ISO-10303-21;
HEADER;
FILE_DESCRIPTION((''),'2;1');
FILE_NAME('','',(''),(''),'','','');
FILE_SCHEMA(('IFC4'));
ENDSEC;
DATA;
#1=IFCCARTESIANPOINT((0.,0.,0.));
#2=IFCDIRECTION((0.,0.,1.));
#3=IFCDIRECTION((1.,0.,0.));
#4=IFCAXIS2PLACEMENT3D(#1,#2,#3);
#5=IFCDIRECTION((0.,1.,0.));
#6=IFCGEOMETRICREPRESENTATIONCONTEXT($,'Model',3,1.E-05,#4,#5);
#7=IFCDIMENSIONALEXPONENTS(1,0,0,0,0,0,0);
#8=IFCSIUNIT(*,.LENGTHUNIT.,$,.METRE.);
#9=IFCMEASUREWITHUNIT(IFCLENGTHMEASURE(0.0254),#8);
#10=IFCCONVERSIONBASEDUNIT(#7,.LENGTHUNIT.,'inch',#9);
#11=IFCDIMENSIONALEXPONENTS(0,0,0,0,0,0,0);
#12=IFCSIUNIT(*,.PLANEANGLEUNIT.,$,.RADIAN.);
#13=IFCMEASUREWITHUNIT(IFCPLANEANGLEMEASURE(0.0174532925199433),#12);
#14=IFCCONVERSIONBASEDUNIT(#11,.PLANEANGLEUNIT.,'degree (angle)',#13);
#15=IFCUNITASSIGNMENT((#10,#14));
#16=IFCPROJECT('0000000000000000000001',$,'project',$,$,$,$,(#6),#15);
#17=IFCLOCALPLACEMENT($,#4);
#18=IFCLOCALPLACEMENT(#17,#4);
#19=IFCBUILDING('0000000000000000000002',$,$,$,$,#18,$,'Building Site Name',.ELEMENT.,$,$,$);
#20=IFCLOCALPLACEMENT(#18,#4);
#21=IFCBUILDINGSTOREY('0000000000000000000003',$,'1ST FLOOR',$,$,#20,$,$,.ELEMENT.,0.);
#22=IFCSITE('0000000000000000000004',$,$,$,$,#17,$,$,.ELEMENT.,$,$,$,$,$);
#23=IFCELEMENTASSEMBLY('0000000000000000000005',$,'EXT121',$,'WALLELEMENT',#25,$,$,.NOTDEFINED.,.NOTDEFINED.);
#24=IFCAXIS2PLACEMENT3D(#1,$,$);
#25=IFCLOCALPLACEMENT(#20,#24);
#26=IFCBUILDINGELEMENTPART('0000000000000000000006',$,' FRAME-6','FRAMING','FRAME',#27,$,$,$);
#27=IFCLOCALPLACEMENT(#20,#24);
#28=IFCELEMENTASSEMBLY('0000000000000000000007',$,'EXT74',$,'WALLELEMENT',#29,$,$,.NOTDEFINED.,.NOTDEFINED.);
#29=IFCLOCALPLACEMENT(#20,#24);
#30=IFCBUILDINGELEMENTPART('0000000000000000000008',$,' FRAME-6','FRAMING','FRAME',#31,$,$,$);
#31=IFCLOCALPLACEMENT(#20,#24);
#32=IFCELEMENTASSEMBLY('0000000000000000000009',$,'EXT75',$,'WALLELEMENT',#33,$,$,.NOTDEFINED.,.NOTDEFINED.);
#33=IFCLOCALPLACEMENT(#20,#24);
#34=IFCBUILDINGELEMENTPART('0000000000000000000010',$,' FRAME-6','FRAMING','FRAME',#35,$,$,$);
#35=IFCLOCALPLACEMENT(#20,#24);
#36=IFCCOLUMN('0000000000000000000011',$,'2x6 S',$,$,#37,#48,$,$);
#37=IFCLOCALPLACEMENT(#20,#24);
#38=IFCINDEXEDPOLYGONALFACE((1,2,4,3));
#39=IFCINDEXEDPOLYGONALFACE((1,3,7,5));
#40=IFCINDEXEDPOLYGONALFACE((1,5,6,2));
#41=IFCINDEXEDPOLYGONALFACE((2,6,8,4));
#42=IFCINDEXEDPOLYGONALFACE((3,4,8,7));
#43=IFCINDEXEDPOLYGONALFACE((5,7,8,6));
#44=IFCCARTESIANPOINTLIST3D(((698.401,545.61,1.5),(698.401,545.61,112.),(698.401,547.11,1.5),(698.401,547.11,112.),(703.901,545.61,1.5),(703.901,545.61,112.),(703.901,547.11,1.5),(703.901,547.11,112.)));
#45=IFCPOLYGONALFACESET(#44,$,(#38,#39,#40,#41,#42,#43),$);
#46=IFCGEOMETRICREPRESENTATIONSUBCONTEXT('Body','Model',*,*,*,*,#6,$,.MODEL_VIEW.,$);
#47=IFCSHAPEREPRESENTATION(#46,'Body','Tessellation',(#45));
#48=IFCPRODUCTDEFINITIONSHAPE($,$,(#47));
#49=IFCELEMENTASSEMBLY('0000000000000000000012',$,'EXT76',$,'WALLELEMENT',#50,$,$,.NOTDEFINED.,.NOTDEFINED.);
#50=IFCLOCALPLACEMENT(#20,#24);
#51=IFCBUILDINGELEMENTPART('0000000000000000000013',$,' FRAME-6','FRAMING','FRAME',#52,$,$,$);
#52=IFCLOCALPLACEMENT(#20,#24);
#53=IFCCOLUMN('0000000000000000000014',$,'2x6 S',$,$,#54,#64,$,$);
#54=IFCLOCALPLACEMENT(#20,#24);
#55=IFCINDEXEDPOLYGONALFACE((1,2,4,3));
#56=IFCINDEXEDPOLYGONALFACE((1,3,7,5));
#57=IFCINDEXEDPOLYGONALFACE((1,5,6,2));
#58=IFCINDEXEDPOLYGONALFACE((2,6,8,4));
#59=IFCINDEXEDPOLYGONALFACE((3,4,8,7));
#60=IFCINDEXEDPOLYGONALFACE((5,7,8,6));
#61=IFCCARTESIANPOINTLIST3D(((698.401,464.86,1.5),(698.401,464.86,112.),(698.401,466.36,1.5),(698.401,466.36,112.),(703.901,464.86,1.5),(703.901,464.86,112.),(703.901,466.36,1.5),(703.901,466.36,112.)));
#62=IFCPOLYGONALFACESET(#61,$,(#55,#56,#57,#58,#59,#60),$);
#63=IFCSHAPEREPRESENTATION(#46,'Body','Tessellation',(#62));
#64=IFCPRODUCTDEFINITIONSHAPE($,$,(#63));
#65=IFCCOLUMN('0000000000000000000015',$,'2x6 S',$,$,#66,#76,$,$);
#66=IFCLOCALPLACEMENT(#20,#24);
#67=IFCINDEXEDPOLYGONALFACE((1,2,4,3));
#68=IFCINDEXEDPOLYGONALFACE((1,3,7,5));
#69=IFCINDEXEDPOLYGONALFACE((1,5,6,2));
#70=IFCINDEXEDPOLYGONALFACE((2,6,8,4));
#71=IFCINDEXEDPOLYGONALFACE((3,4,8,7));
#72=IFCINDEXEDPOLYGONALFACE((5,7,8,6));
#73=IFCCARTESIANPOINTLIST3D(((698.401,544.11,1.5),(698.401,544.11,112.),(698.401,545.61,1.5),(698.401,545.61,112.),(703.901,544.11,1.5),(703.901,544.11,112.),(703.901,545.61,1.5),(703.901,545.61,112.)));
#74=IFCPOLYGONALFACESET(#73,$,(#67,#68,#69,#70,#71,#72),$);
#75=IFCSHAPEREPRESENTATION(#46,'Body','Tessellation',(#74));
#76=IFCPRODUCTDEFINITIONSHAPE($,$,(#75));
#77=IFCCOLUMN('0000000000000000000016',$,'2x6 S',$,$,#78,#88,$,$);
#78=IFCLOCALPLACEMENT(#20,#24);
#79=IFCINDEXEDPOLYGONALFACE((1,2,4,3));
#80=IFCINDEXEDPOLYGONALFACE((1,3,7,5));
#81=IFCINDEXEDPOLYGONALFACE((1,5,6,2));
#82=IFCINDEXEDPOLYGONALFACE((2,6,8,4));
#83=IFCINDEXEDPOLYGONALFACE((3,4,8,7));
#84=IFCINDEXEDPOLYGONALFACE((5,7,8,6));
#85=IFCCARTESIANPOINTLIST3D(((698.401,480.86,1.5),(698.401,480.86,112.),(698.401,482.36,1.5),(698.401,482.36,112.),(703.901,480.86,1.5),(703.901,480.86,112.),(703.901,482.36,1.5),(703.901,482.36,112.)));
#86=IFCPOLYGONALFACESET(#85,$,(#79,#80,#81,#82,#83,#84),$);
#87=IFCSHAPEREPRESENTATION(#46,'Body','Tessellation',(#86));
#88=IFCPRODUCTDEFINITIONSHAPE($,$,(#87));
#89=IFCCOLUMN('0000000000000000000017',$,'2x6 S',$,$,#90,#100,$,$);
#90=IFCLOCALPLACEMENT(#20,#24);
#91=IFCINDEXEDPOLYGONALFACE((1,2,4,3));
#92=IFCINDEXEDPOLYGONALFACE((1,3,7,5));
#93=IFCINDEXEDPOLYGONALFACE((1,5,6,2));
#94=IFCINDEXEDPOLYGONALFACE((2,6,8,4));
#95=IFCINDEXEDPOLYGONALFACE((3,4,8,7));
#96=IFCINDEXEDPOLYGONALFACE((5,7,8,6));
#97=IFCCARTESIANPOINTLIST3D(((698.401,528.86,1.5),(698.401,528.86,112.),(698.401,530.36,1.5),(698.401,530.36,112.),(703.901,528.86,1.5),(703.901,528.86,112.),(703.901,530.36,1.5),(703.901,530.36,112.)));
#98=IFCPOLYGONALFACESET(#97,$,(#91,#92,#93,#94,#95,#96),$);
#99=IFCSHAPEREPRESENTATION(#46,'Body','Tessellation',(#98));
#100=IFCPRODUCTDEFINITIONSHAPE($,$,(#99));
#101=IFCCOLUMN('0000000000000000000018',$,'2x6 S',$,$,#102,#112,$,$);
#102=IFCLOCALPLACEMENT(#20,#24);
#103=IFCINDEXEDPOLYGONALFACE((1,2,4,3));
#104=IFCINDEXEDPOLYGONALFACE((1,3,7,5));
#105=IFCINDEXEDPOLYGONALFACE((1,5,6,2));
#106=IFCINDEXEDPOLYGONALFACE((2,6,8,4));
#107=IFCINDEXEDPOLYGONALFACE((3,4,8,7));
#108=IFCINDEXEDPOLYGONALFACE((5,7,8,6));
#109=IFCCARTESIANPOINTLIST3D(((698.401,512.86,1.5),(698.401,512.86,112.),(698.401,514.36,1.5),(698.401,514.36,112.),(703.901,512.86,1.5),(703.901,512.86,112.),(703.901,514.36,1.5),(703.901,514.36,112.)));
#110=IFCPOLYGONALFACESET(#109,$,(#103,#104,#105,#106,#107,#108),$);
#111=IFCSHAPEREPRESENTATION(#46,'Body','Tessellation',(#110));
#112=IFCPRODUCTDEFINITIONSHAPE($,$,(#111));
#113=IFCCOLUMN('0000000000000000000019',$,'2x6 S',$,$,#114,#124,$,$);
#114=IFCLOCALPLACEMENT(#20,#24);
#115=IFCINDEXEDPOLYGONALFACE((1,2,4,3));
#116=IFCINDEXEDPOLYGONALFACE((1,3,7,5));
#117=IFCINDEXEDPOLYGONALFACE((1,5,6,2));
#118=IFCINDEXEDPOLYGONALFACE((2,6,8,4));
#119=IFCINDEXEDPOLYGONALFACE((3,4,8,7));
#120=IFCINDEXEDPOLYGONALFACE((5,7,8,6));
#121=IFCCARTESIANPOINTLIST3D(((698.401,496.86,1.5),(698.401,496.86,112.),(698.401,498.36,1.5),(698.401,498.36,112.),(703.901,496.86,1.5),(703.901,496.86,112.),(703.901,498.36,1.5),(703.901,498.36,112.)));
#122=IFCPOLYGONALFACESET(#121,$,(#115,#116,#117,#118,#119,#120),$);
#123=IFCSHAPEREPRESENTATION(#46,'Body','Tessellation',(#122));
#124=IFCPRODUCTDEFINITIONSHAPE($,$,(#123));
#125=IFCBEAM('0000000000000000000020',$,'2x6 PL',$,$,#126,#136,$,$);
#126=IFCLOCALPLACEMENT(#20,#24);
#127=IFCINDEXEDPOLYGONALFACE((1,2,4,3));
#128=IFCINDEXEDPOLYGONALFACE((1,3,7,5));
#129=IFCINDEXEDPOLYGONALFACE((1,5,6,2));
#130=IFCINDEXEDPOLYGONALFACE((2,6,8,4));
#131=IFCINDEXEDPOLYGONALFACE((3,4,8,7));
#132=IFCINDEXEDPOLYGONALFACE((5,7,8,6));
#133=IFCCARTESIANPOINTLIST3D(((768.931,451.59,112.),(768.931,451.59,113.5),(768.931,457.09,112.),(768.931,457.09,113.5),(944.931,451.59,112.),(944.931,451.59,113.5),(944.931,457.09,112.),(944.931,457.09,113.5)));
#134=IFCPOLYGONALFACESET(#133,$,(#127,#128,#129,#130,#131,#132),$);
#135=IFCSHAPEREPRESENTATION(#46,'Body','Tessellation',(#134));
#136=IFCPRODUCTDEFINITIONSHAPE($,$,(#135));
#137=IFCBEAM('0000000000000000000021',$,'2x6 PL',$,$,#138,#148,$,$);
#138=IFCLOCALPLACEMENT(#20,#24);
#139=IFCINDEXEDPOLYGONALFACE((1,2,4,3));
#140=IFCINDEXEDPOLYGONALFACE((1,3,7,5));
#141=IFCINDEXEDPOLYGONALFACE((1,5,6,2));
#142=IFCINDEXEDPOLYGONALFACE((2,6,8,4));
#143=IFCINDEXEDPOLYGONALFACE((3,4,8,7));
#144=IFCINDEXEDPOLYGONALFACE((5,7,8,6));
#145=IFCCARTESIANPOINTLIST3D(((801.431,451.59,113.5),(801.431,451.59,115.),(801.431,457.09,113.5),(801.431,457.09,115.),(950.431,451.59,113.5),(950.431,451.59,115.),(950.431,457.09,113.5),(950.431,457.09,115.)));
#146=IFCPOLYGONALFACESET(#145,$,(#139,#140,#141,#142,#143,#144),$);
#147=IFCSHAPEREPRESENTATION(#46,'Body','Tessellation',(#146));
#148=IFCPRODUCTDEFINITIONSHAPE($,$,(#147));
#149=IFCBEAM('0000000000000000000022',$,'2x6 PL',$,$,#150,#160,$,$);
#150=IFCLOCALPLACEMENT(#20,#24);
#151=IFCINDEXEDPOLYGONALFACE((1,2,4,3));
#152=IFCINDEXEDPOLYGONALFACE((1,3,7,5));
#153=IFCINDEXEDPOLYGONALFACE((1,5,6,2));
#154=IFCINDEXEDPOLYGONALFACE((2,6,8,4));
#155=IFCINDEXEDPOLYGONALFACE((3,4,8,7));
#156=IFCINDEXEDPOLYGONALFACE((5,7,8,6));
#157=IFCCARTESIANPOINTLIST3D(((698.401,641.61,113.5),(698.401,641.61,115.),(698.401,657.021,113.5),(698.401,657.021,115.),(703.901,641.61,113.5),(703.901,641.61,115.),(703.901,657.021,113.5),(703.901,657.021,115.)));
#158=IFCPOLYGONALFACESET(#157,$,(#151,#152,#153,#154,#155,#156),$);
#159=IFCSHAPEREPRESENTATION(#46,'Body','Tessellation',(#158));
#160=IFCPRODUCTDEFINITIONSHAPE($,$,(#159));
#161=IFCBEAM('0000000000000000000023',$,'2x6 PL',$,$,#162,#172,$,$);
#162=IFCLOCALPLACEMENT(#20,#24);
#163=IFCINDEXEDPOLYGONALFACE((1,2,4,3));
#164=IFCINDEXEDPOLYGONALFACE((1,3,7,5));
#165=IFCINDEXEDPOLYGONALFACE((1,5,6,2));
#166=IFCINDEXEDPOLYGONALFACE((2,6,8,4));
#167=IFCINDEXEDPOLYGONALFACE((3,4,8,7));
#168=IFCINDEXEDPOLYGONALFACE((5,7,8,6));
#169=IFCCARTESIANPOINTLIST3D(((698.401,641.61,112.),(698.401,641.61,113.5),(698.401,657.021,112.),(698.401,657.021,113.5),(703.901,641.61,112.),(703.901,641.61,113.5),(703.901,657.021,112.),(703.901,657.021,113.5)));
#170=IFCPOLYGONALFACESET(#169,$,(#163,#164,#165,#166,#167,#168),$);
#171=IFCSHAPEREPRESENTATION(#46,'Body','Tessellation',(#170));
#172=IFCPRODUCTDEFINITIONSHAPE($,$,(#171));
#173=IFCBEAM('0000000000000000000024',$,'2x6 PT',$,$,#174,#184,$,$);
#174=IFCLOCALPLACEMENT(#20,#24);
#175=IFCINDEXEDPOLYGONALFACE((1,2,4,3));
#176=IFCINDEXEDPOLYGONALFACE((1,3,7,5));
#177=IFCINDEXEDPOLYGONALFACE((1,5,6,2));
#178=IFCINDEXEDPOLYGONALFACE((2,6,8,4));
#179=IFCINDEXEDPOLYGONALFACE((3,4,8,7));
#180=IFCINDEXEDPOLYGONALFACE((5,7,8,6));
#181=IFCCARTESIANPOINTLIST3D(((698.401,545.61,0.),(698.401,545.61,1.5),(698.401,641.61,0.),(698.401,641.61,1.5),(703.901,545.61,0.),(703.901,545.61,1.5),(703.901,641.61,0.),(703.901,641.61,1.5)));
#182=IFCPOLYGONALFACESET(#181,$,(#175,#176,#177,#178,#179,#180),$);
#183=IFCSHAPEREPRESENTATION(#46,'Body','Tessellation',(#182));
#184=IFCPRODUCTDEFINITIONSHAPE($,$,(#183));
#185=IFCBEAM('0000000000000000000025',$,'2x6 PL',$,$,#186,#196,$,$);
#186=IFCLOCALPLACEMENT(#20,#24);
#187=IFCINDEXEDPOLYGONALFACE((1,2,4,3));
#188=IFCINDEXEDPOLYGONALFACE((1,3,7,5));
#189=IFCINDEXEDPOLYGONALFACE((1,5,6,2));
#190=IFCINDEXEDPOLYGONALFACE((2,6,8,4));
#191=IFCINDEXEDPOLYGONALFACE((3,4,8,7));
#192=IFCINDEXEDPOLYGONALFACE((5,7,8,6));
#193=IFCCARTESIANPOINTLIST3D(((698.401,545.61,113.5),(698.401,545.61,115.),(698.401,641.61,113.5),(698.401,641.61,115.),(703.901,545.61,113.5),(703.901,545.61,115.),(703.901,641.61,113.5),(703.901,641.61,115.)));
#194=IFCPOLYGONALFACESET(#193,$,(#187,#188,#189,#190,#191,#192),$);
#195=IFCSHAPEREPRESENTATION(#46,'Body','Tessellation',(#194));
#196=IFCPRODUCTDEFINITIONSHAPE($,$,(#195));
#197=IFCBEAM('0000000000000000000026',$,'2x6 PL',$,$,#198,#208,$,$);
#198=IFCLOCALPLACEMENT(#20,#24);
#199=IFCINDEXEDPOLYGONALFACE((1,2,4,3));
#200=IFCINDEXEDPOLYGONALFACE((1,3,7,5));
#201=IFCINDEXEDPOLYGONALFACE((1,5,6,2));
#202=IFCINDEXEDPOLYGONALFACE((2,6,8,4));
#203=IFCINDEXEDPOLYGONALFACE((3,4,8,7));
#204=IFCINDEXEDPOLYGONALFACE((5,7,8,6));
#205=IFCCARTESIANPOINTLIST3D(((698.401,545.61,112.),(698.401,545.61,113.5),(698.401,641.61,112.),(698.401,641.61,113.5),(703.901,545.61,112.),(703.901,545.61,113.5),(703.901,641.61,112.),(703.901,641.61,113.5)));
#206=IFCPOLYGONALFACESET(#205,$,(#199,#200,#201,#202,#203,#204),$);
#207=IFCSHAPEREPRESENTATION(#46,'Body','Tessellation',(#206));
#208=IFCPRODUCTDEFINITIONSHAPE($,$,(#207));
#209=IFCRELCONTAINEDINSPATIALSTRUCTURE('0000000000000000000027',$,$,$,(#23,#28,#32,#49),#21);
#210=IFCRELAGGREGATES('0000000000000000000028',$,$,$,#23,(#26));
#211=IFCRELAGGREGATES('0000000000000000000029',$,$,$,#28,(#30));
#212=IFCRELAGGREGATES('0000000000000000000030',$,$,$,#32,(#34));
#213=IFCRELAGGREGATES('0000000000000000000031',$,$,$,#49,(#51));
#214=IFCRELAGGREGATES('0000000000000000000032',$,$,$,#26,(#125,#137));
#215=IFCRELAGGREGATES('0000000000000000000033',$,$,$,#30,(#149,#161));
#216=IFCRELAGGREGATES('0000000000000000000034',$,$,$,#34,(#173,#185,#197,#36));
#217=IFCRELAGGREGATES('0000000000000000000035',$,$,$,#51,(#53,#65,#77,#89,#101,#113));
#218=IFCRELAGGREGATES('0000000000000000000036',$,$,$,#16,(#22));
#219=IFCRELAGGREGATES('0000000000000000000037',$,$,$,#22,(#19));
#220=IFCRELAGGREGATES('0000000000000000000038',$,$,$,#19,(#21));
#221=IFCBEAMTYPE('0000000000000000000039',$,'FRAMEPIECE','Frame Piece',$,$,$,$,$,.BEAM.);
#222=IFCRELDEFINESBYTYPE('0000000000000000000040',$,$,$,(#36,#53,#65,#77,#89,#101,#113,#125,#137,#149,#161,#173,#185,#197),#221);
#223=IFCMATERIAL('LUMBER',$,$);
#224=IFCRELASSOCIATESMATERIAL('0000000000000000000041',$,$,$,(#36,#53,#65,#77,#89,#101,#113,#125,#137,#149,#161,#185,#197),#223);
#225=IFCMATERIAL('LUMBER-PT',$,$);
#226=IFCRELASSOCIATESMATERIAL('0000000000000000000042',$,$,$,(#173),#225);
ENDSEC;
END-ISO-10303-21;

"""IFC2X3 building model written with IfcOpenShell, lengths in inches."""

from ifc_helpers import new_model, entity, si_unit, converted_unit, direction, frame, frame_2d, origin_with_axes, place, context, subcontext, project, spatial, rectangle, extrude, material, type_object, element, aggregate, save


model = new_model("IFC2X3")

# Units and contexts
model_context = context("Model", 3, precision=1e-05, world=origin_with_axes(), true_north=direction((0.0, 1.0, 0.0)))
body_context = subcontext(model_context, "Body", "Model", "MODEL_VIEW")
ifc_project = project(units=[converted_unit("LENGTHUNIT", "inch", entity("IfcLengthMeasure", 0.0254), si_unit("LENGTHUNIT", "METRE"), dimensions=[1, 0, 0, 0, 0, 0, 0]), converted_unit("PLANEANGLEUNIT", "degree (angle)", entity("IfcPlaneAngleMeasure", 0.0174532925199433), si_unit("PLANEANGLEUNIT", "RADIAN"), dimensions=[0, 0, 0, 0, 0, 0, 0])], contexts=[model_context])

# Site, building, storey
site_placement = place(None, origin_with_axes())
site = spatial("IfcSite", under=ifc_project, at=site_placement, CompositionType="ELEMENT")
building_placement = place(site_placement, origin_with_axes())
building = spatial("IfcBuilding", under=site, at=building_placement, LongName="Building Site Name", CompositionType="ELEMENT")
storey_placement = place(building_placement, origin_with_axes())
storey = spatial("IfcBuildingStorey", under=building, at=storey_placement, Name="1ST FLOOR", CompositionType="ELEMENT", Elevation=0.0)

# Element assembly, building element part
assembly_1_placement = place(storey_placement, origin_with_axes())
assembly_1 = element("IfcElementAssembly", 1, at=assembly_1_placement, inside=storey, Name="EXT121", ObjectType="WALLELEMENT", AssemblyPlace="NOTDEFINED", PredefinedType="NOTDEFINED")
building_element_part_1 = element("IfcBuildingElementPart", 2, Name=" FRAME-6", Description="FRAMING", ObjectType="FRAME")
aggregate(assembly_1, [building_element_part_1])
ifc_material_1 = material(Name="LUMBER")
beam_type = type_object("IfcBeamType", Name="FRAMEPIECE", Description="Frame Piece", PredefinedType="BEAM")

# Element assembly, building element part
assembly_2_placement = place(storey_placement, origin_with_axes())
assembly_2 = element("IfcElementAssembly", 3, at=assembly_2_placement, inside=storey, Name="EXT74", ObjectType="WALLELEMENT", AssemblyPlace="NOTDEFINED", PredefinedType="NOTDEFINED")
building_element_part_2 = element("IfcBuildingElementPart", 4, Name=" FRAME-6", Description="FRAMING", ObjectType="FRAME")
aggregate(assembly_2, [building_element_part_2])

# Element assemblies, building element parts, columns
assembly_3_placement = place(storey_placement, origin_with_axes())
assembly_3 = element("IfcElementAssembly", 5, at=assembly_3_placement, inside=storey, Name="EXT75", ObjectType="WALLELEMENT", AssemblyPlace="NOTDEFINED", PredefinedType="NOTDEFINED")
building_element_part_3 = element("IfcBuildingElementPart", 6, Name=" FRAME-6", Description="FRAMING", ObjectType="FRAME")
aggregate(assembly_3, [building_element_part_3])
column_1_placement = place(assembly_3_placement, frame((701.151, 546.36, 1.5), z_axis=(0.0, 0.0, 1.0), x_axis=(0.0, 1.0, 0.0)))
column_1 = element("IfcColumn", 7, at=column_1_placement, type_object=beam_type, material=ifc_material_1, Name="2x6 S", context=body_context, shape_type="SweptSolid", body=[
    extrude(rectangle(XDim=1.5, YDim=5.5, at=frame_2d((0.0, 0.0), x_axis=(-1.0, 0.0))), frame((0.0, 0.0, 0.0), z_axis=(0.0, 0.0, 1.0), x_axis=(1.0, 0.0, 0.0)), (0.0, 0.0, 1.0), 110.5),
])
assembly_4_placement = place(storey_placement, origin_with_axes())
assembly_4 = element("IfcElementAssembly", 8, at=assembly_4_placement, inside=storey, Name="EXT76", ObjectType="WALLELEMENT", AssemblyPlace="NOTDEFINED", PredefinedType="NOTDEFINED")
building_element_part_4 = element("IfcBuildingElementPart", 9, Name=" FRAME-6", Description="FRAMING", ObjectType="FRAME")
aggregate(assembly_4, [building_element_part_4])
column_2_placement = place(assembly_4_placement, frame((701.151, 465.61, 112.0), z_axis=(0.0, 0.0, -1.0), x_axis=(0.0, -1.0, 0.0)))
column_2 = element("IfcColumn", 10, at=column_2_placement, type_object=beam_type, material=ifc_material_1, Name="2x6 S", context=body_context, shape_type="SweptSolid", body=[
    extrude(rectangle(XDim=1.5, YDim=5.5, at=frame_2d((0.0, 0.0), x_axis=(-1.0, 0.0))), origin_with_axes(), (0.0, 0.0, 1.0), 110.5),
])
column_3_placement = place(assembly_4_placement, frame((701.151, 544.86, 112.0), z_axis=(0.0, 0.0, -1.0), x_axis=(0.0, -1.0, 0.0)))
column_3 = element("IfcColumn", 11, at=column_3_placement, type_object=beam_type, material=ifc_material_1, Name="2x6 S", context=body_context, shape_type="SweptSolid", body=[
    extrude(rectangle(XDim=1.5, YDim=5.5, at=frame_2d((0.0, 0.0), x_axis=(-1.0, 0.0))), origin_with_axes(), (0.0, 0.0, 1.0), 110.5),
])
column_4_placement = place(assembly_4_placement, frame((701.151, 481.61, 112.0), z_axis=(0.0, 0.0, -1.0), x_axis=(0.0, -1.0, 0.0)))
column_4 = element("IfcColumn", 12, at=column_4_placement, type_object=beam_type, material=ifc_material_1, Name="2x6 S", context=body_context, shape_type="SweptSolid", body=[
    extrude(rectangle(XDim=1.5, YDim=5.5, at=frame_2d((0.0, 0.0), x_axis=(-1.0, 0.0))), origin_with_axes(), (0.0, 0.0, 1.0), 110.5),
])
column_5_placement = place(assembly_4_placement, frame((701.151, 529.61, 112.0), z_axis=(0.0, 0.0, -1.0), x_axis=(0.0, -1.0, 0.0)))
column_5 = element("IfcColumn", 13, at=column_5_placement, type_object=beam_type, material=ifc_material_1, Name="2x6 S", context=body_context, shape_type="SweptSolid", body=[
    extrude(rectangle(XDim=1.5, YDim=5.5, at=frame_2d((0.0, 0.0), x_axis=(-1.0, 0.0))), origin_with_axes(), (0.0, 0.0, 1.0), 110.5),
])
column_6_placement = place(assembly_4_placement, frame((701.151, 513.61, 112.0), z_axis=(0.0, 0.0, -1.0), x_axis=(0.0, -1.0, 0.0)))
column_6 = element("IfcColumn", 14, at=column_6_placement, type_object=beam_type, material=ifc_material_1, Name="2x6 S", context=body_context, shape_type="SweptSolid", body=[
    extrude(rectangle(XDim=1.5, YDim=5.5, at=frame_2d((0.0, 0.0), x_axis=(-1.0, 0.0))), origin_with_axes(), (0.0, 0.0, 1.0), 110.5),
])
column_7_placement = place(assembly_4_placement, frame((701.151, 497.61, 112.0), z_axis=(0.0, 0.0, -1.0), x_axis=(0.0, -1.0, 0.0)))
column_7 = element("IfcColumn", 15, at=column_7_placement, type_object=beam_type, material=ifc_material_1, Name="2x6 S", context=body_context, shape_type="SweptSolid", body=[
    extrude(rectangle(XDim=1.5, YDim=5.5, at=frame_2d((0.0, 0.0), x_axis=(-1.0, 0.0))), origin_with_axes(), (0.0, 0.0, 1.0), 110.5),
])

# Beams
beam_1_placement = place(assembly_1_placement, frame((768.931, 454.34, 112.75), z_axis=(1.0, 0.0, 0.0), x_axis=(0.0, 0.0, -1.0)))
beam_1 = element("IfcBeam", 16, at=beam_1_placement, type_object=beam_type, material=ifc_material_1, Name="2x6 PL", context=body_context, shape_type="SweptSolid", body=[
    extrude(rectangle(XDim=1.5, YDim=5.5, at=frame_2d((0.0, 0.0), x_axis=(-1.0, 0.0))), origin_with_axes(), (0.0, 0.0, 1.0), 176.0),
])
beam_2_placement = place(assembly_1_placement, frame((801.431, 454.34, 114.25), z_axis=(1.0, 0.0, 0.0), x_axis=(0.0, 0.0, -1.0)))
beam_2 = element("IfcBeam", 17, at=beam_2_placement, type_object=beam_type, material=ifc_material_1, Name="2x6 PL", context=body_context, shape_type="SweptSolid", body=[
    extrude(rectangle(XDim=1.5, YDim=5.5, at=frame_2d((0.0, 0.0), x_axis=(-1.0, 0.0))), origin_with_axes(), (0.0, 0.0, 1.0), 149.0),
])
aggregate(building_element_part_1, [beam_1, beam_2])
beam_3_placement = place(assembly_2_placement, frame((701.151, 641.61, 114.25), z_axis=(0.0, 1.0, 0.0), x_axis=(0.0, 0.0, -1.0)))
beam_3 = element("IfcBeam", 18, at=beam_3_placement, type_object=beam_type, material=ifc_material_1, Name="2x6 PL", context=body_context, shape_type="SweptSolid", body=[
    extrude(rectangle(XDim=1.5, YDim=5.5, at=frame_2d((0.0, 0.0), x_axis=(-1.0, 0.0))), origin_with_axes(), (0.0, 0.0, 1.0), 15.412),
])
beam_4_placement = place(assembly_2_placement, frame((701.151, 641.61, 112.75), z_axis=(0.0, 1.0, 0.0), x_axis=(0.0, 0.0, -1.0)))
beam_4 = element("IfcBeam", 19, at=beam_4_placement, type_object=beam_type, material=ifc_material_1, Name="2x6 PL", context=body_context, shape_type="SweptSolid", body=[
    extrude(rectangle(XDim=1.5, YDim=5.5, at=frame_2d((0.0, 0.0), x_axis=(-1.0, 0.0))), origin_with_axes(), (0.0, 0.0, 1.0), 15.412),
])
aggregate(building_element_part_2, [beam_3, beam_4])
ifc_material_2 = material(Name="LUMBER-PT")
beam_5_placement = place(assembly_3_placement, frame((701.151, 641.61, 0.75), z_axis=(0.0, -1.0, 0.0), x_axis=(0.0, 0.0, 1.0)))
beam_5 = element("IfcBeam", 20, at=beam_5_placement, type_object=beam_type, material=ifc_material_2, Name="2x6 PT", context=body_context, shape_type="SweptSolid", body=[
    extrude(rectangle(XDim=1.5, YDim=5.5, at=frame_2d((0.0, 0.0), x_axis=(-1.0, 0.0))), origin_with_axes(), (0.0, 0.0, 1.0), 96.0),
])
beam_6_placement = place(assembly_3_placement, frame((701.151, 545.61, 114.25), z_axis=(0.0, 1.0, 0.0), x_axis=(0.0, 0.0, -1.0)))
beam_6 = element("IfcBeam", 21, at=beam_6_placement, type_object=beam_type, material=ifc_material_1, Name="2x6 PL", context=body_context, shape_type="SweptSolid", body=[
    extrude(rectangle(XDim=1.5, YDim=5.5, at=frame_2d((0.0, 0.0), x_axis=(-1.0, 0.0))), origin_with_axes(), (0.0, 0.0, 1.0), 96.0),
])
beam_7_placement = place(assembly_3_placement, frame((701.151, 545.61, 112.75), z_axis=(0.0, 1.0, 0.0), x_axis=(0.0, 0.0, -1.0)))
beam_7 = element("IfcBeam", 22, at=beam_7_placement, type_object=beam_type, material=ifc_material_1, Name="2x6 PL", context=body_context, shape_type="SweptSolid", body=[
    extrude(rectangle(XDim=1.5, YDim=5.5, at=frame_2d((0.0, 0.0), x_axis=(-1.0, 0.0))), origin_with_axes(), (0.0, 0.0, 1.0), 96.0),
])
aggregate(building_element_part_3, [beam_5, beam_6, beam_7, column_1])
aggregate(building_element_part_4, [column_2, column_3, column_4, column_5, column_6, column_7])

save(model, "model.ifc")
